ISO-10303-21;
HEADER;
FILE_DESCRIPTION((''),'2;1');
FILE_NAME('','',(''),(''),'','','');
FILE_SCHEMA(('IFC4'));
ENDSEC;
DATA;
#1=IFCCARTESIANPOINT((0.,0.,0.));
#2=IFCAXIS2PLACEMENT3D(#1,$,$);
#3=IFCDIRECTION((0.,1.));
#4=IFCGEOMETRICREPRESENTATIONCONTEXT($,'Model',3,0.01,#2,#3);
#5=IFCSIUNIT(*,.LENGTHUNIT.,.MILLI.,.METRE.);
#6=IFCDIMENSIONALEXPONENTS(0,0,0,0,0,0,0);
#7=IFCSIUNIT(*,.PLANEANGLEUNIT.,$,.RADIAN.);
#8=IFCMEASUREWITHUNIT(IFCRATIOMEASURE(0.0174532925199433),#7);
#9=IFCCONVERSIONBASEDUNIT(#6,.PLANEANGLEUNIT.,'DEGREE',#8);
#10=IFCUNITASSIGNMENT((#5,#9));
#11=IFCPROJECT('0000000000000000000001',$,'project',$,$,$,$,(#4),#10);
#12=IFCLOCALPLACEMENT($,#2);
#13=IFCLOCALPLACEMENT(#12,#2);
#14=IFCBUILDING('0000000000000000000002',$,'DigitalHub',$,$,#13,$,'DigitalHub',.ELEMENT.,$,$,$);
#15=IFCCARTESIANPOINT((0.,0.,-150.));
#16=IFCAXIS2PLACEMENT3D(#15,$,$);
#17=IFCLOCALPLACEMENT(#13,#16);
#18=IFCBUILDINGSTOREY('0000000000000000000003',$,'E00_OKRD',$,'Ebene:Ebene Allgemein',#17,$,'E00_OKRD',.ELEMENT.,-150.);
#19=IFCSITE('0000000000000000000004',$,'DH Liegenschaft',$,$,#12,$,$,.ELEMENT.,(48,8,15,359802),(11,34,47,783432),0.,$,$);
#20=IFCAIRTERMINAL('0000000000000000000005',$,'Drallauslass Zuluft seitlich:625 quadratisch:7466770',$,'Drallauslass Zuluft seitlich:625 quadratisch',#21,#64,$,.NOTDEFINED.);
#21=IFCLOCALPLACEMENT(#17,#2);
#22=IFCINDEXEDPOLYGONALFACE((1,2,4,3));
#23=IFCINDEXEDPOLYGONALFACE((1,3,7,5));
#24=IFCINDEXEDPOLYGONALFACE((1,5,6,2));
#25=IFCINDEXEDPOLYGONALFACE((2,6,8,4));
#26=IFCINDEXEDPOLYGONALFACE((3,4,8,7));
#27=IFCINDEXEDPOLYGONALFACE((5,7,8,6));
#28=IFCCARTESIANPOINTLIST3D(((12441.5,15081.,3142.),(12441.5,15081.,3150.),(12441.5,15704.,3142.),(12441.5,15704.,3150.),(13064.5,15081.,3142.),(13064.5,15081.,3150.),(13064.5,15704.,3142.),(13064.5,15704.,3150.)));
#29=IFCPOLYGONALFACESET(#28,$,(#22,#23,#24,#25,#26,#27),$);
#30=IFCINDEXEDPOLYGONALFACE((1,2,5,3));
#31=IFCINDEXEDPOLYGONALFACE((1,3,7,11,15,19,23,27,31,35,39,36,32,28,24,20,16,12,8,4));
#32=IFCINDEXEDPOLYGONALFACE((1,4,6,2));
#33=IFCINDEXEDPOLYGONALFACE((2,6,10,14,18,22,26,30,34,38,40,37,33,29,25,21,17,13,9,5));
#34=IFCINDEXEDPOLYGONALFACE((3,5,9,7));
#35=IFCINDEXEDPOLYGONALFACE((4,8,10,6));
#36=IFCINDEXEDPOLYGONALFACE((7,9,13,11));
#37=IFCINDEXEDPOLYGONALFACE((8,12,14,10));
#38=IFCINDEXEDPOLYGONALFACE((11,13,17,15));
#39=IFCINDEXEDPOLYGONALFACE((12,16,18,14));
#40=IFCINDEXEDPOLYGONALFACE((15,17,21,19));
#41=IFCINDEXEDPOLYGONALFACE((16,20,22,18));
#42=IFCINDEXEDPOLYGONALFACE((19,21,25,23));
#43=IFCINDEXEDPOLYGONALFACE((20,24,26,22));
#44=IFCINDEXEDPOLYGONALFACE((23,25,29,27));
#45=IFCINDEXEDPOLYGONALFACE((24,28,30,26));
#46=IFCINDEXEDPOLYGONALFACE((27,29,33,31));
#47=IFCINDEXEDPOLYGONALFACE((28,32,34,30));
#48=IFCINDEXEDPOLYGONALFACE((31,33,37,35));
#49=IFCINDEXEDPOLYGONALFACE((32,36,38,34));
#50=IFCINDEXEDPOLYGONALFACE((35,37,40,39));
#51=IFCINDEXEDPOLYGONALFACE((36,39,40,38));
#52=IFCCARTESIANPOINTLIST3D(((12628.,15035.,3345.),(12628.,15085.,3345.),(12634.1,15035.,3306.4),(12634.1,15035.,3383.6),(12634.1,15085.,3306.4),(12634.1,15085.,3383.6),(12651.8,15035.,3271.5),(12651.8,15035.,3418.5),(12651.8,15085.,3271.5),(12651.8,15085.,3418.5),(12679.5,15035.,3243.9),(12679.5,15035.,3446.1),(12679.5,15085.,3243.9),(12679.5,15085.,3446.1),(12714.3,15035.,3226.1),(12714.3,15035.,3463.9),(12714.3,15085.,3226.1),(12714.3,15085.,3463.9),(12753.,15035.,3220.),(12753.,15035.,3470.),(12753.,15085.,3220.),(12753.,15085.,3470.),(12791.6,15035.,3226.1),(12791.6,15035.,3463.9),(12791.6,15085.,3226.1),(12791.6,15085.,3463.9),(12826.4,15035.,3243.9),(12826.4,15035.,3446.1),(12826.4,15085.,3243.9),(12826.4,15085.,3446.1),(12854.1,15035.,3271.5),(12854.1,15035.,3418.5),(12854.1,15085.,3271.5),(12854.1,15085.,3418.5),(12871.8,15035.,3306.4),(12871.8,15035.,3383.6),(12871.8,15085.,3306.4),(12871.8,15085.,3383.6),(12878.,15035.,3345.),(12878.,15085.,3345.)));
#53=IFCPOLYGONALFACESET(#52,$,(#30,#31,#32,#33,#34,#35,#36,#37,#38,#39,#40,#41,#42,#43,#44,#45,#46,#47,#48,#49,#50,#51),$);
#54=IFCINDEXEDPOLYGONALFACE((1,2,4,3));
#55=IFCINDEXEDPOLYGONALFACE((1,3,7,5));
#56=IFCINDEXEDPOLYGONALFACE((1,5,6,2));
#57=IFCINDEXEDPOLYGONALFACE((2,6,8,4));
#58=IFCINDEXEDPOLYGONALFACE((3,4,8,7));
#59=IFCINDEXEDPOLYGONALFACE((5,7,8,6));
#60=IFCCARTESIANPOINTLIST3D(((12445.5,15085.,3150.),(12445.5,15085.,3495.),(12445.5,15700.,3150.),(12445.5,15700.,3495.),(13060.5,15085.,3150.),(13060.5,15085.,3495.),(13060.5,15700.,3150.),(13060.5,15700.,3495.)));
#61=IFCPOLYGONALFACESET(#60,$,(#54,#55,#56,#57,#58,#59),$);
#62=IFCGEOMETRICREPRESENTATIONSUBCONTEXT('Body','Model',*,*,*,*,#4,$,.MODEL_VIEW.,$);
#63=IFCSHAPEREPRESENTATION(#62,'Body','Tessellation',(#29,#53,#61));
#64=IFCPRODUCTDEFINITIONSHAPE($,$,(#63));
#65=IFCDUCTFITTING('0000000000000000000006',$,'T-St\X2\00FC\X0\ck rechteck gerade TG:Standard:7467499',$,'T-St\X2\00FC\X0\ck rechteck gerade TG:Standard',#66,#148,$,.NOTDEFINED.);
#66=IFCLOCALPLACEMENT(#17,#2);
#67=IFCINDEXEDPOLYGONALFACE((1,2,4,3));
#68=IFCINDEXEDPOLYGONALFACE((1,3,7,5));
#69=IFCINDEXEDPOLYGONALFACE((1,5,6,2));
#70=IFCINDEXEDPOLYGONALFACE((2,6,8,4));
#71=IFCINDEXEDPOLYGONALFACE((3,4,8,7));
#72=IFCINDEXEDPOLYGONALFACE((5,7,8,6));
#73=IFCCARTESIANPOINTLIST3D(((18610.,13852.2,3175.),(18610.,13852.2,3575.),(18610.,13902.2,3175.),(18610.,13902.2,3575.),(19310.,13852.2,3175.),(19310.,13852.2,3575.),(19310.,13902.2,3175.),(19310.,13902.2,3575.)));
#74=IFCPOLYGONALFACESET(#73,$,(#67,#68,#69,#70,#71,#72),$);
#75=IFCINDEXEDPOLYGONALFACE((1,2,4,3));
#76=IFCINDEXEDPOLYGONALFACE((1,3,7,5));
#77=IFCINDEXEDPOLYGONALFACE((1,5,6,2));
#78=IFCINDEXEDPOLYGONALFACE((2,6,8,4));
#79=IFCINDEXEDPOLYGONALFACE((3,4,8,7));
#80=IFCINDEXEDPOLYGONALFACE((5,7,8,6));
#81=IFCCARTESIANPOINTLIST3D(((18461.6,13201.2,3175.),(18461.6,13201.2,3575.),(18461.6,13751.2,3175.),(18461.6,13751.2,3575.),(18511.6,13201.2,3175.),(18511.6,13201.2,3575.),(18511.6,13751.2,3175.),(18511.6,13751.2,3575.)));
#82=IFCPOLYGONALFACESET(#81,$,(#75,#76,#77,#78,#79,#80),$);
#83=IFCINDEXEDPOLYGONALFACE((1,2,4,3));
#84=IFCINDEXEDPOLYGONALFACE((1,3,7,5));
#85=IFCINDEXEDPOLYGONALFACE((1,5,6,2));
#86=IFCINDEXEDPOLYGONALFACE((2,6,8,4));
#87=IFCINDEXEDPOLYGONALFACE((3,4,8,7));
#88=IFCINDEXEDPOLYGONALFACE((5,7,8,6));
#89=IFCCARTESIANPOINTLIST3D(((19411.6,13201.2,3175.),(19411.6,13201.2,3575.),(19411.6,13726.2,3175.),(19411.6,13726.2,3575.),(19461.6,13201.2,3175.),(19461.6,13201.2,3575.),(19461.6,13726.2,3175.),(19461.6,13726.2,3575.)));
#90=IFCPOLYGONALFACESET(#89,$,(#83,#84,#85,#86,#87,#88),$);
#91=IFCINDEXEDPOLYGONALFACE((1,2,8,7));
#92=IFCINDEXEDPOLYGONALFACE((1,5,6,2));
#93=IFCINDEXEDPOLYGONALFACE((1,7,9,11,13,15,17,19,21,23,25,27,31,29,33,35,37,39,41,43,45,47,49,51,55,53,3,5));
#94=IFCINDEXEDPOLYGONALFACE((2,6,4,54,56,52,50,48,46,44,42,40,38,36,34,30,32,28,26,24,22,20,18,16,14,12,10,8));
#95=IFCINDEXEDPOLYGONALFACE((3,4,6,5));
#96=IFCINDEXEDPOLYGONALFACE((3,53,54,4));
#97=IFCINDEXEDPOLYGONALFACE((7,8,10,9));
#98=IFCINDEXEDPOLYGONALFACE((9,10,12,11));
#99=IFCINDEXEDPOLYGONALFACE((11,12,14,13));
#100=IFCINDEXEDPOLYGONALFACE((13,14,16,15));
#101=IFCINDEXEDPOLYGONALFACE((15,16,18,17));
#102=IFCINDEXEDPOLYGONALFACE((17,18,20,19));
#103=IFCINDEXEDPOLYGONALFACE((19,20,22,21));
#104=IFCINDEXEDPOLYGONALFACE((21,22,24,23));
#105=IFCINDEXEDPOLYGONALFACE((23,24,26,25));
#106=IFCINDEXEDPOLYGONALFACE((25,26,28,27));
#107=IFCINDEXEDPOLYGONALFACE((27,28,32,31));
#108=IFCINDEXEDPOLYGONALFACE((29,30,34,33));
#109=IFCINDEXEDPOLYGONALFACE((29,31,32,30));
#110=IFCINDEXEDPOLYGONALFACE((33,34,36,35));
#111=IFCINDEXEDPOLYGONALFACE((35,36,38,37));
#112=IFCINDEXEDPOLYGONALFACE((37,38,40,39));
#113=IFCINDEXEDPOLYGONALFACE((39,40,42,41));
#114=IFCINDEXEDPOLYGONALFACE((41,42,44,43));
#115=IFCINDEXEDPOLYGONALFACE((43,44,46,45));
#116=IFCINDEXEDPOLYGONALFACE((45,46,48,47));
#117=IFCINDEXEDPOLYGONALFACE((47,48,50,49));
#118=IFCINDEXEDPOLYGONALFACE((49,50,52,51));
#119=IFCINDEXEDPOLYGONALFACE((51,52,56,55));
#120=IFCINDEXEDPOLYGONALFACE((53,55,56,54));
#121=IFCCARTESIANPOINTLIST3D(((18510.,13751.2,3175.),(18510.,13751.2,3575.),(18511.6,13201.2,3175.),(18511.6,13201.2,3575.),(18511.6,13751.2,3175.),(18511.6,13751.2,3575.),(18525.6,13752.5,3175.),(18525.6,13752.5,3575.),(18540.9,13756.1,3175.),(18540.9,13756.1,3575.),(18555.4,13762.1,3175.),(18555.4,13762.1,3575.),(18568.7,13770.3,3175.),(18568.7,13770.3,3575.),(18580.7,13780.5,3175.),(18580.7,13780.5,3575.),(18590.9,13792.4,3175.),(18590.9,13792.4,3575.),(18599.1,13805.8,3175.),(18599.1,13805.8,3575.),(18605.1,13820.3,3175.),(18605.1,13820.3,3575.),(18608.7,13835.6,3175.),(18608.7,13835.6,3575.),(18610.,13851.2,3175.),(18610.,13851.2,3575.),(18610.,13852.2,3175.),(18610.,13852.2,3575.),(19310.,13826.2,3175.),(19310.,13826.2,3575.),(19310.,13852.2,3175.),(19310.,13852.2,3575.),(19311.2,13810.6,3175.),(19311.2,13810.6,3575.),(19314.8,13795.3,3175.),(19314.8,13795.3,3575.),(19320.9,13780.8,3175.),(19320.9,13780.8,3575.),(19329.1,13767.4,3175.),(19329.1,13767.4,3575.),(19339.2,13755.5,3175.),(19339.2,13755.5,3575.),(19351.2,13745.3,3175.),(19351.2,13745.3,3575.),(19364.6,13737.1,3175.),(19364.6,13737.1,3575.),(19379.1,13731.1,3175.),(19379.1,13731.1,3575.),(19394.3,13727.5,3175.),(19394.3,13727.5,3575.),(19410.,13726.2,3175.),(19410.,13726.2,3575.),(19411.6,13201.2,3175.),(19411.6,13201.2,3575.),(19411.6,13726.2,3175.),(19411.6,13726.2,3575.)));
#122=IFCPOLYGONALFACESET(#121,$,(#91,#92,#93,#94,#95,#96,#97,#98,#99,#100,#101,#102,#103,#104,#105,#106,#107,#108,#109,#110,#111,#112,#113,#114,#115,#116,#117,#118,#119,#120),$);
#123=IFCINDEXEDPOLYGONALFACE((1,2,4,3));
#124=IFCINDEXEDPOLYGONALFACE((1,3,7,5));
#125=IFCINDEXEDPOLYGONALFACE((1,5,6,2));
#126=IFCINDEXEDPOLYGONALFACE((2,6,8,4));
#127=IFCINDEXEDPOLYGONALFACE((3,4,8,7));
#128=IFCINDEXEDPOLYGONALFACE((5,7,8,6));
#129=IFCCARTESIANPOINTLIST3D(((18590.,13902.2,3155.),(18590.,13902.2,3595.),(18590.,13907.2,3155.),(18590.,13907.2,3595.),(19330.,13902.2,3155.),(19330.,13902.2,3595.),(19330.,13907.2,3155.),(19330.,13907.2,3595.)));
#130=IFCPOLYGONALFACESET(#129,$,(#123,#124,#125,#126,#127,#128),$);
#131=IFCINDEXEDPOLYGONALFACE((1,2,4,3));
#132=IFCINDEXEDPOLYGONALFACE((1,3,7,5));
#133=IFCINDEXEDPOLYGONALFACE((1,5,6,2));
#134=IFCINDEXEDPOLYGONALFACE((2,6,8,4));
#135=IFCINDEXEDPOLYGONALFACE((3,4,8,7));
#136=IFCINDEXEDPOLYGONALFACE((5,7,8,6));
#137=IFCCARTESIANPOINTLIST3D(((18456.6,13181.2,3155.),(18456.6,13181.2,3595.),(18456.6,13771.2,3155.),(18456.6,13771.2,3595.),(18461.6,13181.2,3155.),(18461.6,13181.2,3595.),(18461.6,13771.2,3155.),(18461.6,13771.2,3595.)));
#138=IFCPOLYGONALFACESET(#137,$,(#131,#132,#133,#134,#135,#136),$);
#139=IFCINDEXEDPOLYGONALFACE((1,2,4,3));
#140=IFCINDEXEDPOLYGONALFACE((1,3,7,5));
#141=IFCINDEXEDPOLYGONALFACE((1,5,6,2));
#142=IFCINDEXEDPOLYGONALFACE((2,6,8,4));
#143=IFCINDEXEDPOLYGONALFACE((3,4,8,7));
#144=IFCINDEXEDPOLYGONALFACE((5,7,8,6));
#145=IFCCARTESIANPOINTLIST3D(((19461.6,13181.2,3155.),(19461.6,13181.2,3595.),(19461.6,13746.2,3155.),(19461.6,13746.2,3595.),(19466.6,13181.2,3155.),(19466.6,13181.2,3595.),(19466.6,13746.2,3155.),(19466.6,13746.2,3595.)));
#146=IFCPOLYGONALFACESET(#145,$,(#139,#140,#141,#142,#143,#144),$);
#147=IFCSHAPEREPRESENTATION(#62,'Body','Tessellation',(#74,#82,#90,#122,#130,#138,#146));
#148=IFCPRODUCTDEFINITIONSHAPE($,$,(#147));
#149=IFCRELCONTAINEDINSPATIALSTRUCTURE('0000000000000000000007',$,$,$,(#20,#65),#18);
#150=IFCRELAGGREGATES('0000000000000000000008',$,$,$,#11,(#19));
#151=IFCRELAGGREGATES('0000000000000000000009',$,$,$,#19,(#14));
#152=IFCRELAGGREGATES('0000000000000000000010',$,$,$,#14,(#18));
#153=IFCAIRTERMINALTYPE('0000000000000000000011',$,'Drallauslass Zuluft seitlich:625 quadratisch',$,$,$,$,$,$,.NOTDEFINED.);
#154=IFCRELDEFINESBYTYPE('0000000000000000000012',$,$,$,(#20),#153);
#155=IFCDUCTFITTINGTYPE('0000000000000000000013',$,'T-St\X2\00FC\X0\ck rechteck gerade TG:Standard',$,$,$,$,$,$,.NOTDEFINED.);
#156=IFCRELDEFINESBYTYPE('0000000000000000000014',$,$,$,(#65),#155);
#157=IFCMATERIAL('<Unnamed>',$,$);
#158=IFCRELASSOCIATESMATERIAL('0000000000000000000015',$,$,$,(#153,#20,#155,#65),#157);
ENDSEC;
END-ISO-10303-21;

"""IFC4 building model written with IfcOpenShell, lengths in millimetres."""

from ifc_helpers import new_model, entity, si_unit, converted_unit, direction, frame, origin, place, context, subcontext, project, spatial, indexed_curve, outline, extrude, source, transform, mapped, material, type_object, type_shapes, element, save


model = new_model("IFC4")

# Units and contexts
model_context = context("Model", 3, precision=0.01, world=origin(), true_north=direction((0.0, 1.0)))
body_context = subcontext(model_context, "Body", "Model", "MODEL_VIEW")
ifc_project = project(units=[si_unit("LENGTHUNIT", "METRE", prefix="MILLI"), converted_unit("PLANEANGLEUNIT", "DEGREE", entity("IfcRatioMeasure", 0.0174532925199433), si_unit("PLANEANGLEUNIT", "RADIAN"), dimensions=[0, 0, 0, 0, 0, 0, 0])], contexts=[model_context])

# Site, building, storey
site_placement = place(None, origin())
site = spatial("IfcSite", under=ifc_project, at=site_placement, Name="DH Liegenschaft", CompositionType="ELEMENT", RefLatitude=(48, 8, 15, 359802), RefLongitude=(11, 34, 47, 783432), RefElevation=0.0)
building_placement = place(site_placement, origin())
building = spatial("IfcBuilding", under=site, at=building_placement, Name="DigitalHub", LongName="DigitalHub", CompositionType="ELEMENT")
storey_placement = place(building_placement, frame((0.0, 0.0, -150.0)))
storey = spatial("IfcBuildingStorey", under=building, at=storey_placement, Name="E00_OKRD", ObjectType="Ebene:Ebene Allgemein", LongName="E00_OKRD", CompositionType="ELEMENT", Elevation=-150.0)

# Shared definitions
ifc_material_1 = material(Name="<Unnamed>")

# Air terminal
air_terminal_type = type_object("IfcAirTerminalType", Name="Drallauslass Zuluft seitlich:625 quadratisch", PredefinedType="NOTDEFINED", material=ifc_material_1)
shared_shape_1 = source(origin(), body_context, "Body", "SweptSolid", [
    extrude(outline(indexed_curve([(-311.5, -311.5), (311.5, -311.5), (311.5, 311.5), (-311.5, 311.5), (-311.5, -311.5)], self_intersect=False)), frame((0.0, 0.0, -8.0), z_axis=(0.0, 0.0, 1.0), x_axis=(-1.0, 0.0, 0.0)), (0.0, 0.0, 1.0), 8.0),
    extrude(outline(indexed_curve([(125.0, 0.0), (118.9, 38.6), (101.1, 73.5), (73.5, 101.1), (38.6, 118.9), (0.0, 125.0), (-38.6, 118.9), (-73.5, 101.1), (-101.1, 73.5), (-118.9, 38.6), (-125.0, 0.0), (-118.9, -38.6), (-101.1, -73.5), (-73.5, -101.1), (-38.6, -118.9), (0.0, -125.0), (38.6, -118.9), (73.5, -101.1), (101.1, -73.5), (118.9, -38.6), (125.0, 0.0)], self_intersect=False)), frame((-357.5, 0.0, 195.0), z_axis=(1.0, 0.0, 0.0), x_axis=(0.0, 1.0, 0.0)), (0.0, 0.0, 1.0), 50.0),
    extrude(outline(indexed_curve([(-307.5, -307.5), (307.5, -307.5), (307.5, 307.5), (-307.5, 307.5), (-307.5, -307.5)], self_intersect=False)), frame((0.0, 0.0, 0.0), z_axis=(0.0, 0.0, 1.0), x_axis=(-1.0, 0.0, 0.0)), (0.0, 0.0, 1.0), 345.0),
])
type_shapes(air_terminal_type, [shared_shape_1])
for number, where, z_axis, x_axis, name in (
    (1, (12753.0, 15392.5, 3150.0), (0.0, 0.0, 1.0), (0.0, 1.0, 0.0), "Drallauslass Zuluft seitlich:625 quadratisch:7466770"),
):
    element("IfcAirTerminal", number, at=place(storey_placement, frame(where, z_axis=z_axis, x_axis=x_axis)), inside=storey, type_object=air_terminal_type, material=ifc_material_1, Name=name, ObjectType="Drallauslass Zuluft seitlich:625 quadratisch", PredefinedType="NOTDEFINED", context=body_context, shape_type="MappedRepresentation", body=[
        mapped(shared_shape_1, transform((0.0, 0.0, 0.0), scale=1.0)),
    ])

# Duct fitting
duct_fitting_type_1 = type_object("IfcDuctFittingType", Name="T-Stück rechteck gerade TG:Standard", PredefinedType="NOTDEFINED", material=ifc_material_1)
shared_shape_2 = source(origin(), body_context, "Body", "SweptSolid", [
    extrude(outline(indexed_curve([(-25.0, -350.0), (25.0, -350.0), (25.0, 350.0), (-25.0, 350.0), (-25.0, -350.0)], self_intersect=False)), frame((0.0, -407.2, -200.0), z_axis=(0.0, 0.0, 1.0), x_axis=(0.0, -1.0, 0.0)), (0.0, 0.0, 1.0), 400.0),
    extrude(outline(indexed_curve([(-25.0, -275.0), (25.0, -275.0), (25.0, 275.0), (-25.0, 275.0), (-25.0, -275.0)], self_intersect=False)), frame((473.4, -6.2, -200.0), z_axis=(0.0, 0.0, 1.0), x_axis=(-1.0, 0.0, 0.0)), (0.0, 0.0, 1.0), 400.0),
    extrude(outline(indexed_curve([(-25.0, -262.5), (25.0, -262.5), (25.0, 262.5), (-25.0, 262.5), (-25.0, -262.5)], self_intersect=False)), frame((-476.6, 6.3, -200.0)), (0.0, 0.0, 1.0), 400.0),
    extrude(outline(indexed_curve([(-450.6, -77.3), (-435.0, -78.5), (-419.7, -82.2), (-405.2, -88.2), (-391.9, -96.4), (-379.9, -106.6), (-369.7, -118.5), (-361.5, -131.9), (-355.5, -146.4), (-351.9, -161.7), (-350.6, -177.3), (-350.6, -178.3), (349.4, -178.3), (349.4, -152.3), (350.6, -136.7), (354.3, -121.4), (360.3, -106.9), (368.5, -93.5), (378.6, -81.6), (390.6, -71.4), (404.0, -63.2), (418.5, -57.2), (433.7, -53.5), (449.4, -52.3), (451.0, -52.3), (451.0, 472.7), (-449.0, 472.7), (-449.0, -77.3), (-450.6, -77.3)], self_intersect=False)), frame((-0.6, -203.9, -200.0), z_axis=(0.0, 0.0, -1.0), x_axis=(-1.0, 0.0, 0.0)), (0.0, 0.0, -1.0), 400.0),
    extrude(outline(indexed_curve([(-2.5, -370.0), (2.5, -370.0), (2.5, 370.0), (-2.5, 370.0), (-2.5, -370.0)], self_intersect=False)), frame((0.0, -434.8, -220.0), z_axis=(0.0, 0.0, 1.0), x_axis=(0.0, 1.0, 0.0)), (0.0, 0.0, 1.0), 440.0),
    extrude(outline(indexed_curve([(-2.5, -295.0), (2.5, -295.0), (2.5, 295.0), (-2.5, 295.0), (-2.5, -295.0)], self_intersect=False)), frame((500.9, -6.2, -220.0), z_axis=(0.0, 0.0, 1.0), x_axis=(-1.0, 0.0, 0.0)), (0.0, 0.0, 1.0), 440.0),
    extrude(outline(indexed_curve([(-2.5, -282.5), (2.5, -282.5), (2.5, 282.5), (-2.5, 282.5), (-2.5, -282.5)], self_intersect=False)), frame((-504.1, 6.3, -220.0), z_axis=(0.0, 0.0, 1.0), x_axis=(-1.0, 0.0, 0.0)), (0.0, 0.0, 1.0), 440.0),
])
type_shapes(duct_fitting_type_1, [shared_shape_2])
duct_fitting_1_placement = place(storey_placement, frame((18960.0, 13470.0, 3375.0), z_axis=(0.0, 0.0, 1.0), x_axis=(-1.0, 0.0, 0.0)))
element("IfcDuctFitting", 2, at=duct_fitting_1_placement, inside=storey, type_object=duct_fitting_type_1, material=ifc_material_1, Name="T-Stück rechteck gerade TG:Standard:7467499", ObjectType="T-Stück rechteck gerade TG:Standard", PredefinedType="NOTDEFINED", context=body_context, shape_type="MappedRepresentation", body=[
    mapped(shared_shape_2, transform((0.0, 0.0, 0.0), scale=1.0)),
])

save(model, "model.ifc")
